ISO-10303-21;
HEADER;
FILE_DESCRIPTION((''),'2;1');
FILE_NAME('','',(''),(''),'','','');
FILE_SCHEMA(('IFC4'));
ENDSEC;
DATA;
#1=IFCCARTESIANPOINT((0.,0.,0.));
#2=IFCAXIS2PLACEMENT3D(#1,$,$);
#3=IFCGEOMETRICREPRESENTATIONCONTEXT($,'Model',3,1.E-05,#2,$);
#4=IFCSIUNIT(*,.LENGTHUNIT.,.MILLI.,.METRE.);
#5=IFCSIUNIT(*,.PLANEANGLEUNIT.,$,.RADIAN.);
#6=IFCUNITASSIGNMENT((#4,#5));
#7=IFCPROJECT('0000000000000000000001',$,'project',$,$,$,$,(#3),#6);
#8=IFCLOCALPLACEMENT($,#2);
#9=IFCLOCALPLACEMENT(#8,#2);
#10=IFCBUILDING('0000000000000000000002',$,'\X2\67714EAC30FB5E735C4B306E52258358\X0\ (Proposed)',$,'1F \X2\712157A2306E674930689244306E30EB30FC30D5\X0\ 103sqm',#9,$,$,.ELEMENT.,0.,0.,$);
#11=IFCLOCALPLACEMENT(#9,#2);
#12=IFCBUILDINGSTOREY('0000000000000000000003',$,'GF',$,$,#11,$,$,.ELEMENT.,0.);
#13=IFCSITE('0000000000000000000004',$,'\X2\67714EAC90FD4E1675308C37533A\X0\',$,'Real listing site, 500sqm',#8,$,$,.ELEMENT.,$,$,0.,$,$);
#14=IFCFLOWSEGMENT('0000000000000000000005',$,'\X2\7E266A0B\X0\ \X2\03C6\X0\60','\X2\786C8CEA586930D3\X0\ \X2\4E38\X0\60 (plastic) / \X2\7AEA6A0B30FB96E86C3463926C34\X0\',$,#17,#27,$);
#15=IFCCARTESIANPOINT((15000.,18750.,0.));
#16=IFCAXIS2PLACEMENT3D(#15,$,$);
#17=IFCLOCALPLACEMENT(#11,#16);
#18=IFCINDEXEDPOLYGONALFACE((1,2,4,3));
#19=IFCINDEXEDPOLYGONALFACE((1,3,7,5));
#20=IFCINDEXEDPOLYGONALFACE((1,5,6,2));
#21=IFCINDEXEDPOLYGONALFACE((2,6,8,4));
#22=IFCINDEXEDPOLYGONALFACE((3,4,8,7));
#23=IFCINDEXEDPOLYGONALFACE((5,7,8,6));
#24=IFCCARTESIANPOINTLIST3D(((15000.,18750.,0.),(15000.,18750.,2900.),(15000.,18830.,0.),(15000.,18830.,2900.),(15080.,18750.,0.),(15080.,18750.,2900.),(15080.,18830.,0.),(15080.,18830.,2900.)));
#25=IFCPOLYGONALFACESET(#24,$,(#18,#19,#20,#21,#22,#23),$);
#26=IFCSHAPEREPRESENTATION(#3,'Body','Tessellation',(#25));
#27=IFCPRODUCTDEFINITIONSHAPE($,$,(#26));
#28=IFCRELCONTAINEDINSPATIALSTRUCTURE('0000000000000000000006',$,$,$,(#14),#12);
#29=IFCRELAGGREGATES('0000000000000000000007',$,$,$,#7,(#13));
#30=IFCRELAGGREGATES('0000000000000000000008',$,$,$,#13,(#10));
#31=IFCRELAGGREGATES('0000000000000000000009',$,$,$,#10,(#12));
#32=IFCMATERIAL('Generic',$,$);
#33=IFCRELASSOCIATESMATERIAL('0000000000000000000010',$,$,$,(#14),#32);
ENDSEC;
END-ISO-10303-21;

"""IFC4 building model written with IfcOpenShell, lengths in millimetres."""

from ifc_helpers import new_model, si_unit, frame, frame_2d, origin, place, context, project, spatial, rectangle, extrude, material, element, save


model = new_model("IFC4")

# Units and contexts
model_context = context("Model", 3, precision=1e-05, world=origin())
ifc_project = project(units=[si_unit("LENGTHUNIT", "METRE", prefix="MILLI"), si_unit("PLANEANGLEUNIT", "RADIAN")], contexts=[model_context])

# Site, building, storey
site_placement = place(None, origin())
site = spatial("IfcSite", under=ifc_project, at=site_placement, Name="東京都世田谷区", ObjectType="Real listing site, 500sqm", CompositionType="ELEMENT", RefElevation=0.0)
building_placement = place(site_placement, origin())
building = spatial("IfcBuilding", under=site, at=building_placement, Name="東京・平屋の別荘 (Proposed)", ObjectType="1F 無垢の杉と鉄のルーフ 103sqm", CompositionType="ELEMENT", ElevationOfRefHeight=0.0, ElevationOfTerrain=0.0)
storey_placement = place(building_placement, origin())
storey = spatial("IfcBuildingStorey", under=building, at=storey_placement, Name="GF", CompositionType="ELEMENT", Elevation=0.0)

# Shared definitions
ifc_material_1 = material(Name="Generic")

# Flow segment
flow_segment_placement = place(storey_placement, frame((15000.0, 18750.0, 0.0)))
element("IfcFlowSegment", 1, at=flow_segment_placement, inside=storey, material=ifc_material_1, Name="縦樋 φ60", Description="硬質塩ビ 丸60 (plastic) / 竪樋・雨水排水", context=model_context, shape_type="SweptSolid", body=[
    extrude(rectangle(XDim=80.0, YDim=80.0, at=frame_2d((40.0, 40.0))), frame((15000.0, 18750.0, 0.0)), (0.0, 0.0, 1.0), 2900.0),
])

save(model, "model.ifc")
